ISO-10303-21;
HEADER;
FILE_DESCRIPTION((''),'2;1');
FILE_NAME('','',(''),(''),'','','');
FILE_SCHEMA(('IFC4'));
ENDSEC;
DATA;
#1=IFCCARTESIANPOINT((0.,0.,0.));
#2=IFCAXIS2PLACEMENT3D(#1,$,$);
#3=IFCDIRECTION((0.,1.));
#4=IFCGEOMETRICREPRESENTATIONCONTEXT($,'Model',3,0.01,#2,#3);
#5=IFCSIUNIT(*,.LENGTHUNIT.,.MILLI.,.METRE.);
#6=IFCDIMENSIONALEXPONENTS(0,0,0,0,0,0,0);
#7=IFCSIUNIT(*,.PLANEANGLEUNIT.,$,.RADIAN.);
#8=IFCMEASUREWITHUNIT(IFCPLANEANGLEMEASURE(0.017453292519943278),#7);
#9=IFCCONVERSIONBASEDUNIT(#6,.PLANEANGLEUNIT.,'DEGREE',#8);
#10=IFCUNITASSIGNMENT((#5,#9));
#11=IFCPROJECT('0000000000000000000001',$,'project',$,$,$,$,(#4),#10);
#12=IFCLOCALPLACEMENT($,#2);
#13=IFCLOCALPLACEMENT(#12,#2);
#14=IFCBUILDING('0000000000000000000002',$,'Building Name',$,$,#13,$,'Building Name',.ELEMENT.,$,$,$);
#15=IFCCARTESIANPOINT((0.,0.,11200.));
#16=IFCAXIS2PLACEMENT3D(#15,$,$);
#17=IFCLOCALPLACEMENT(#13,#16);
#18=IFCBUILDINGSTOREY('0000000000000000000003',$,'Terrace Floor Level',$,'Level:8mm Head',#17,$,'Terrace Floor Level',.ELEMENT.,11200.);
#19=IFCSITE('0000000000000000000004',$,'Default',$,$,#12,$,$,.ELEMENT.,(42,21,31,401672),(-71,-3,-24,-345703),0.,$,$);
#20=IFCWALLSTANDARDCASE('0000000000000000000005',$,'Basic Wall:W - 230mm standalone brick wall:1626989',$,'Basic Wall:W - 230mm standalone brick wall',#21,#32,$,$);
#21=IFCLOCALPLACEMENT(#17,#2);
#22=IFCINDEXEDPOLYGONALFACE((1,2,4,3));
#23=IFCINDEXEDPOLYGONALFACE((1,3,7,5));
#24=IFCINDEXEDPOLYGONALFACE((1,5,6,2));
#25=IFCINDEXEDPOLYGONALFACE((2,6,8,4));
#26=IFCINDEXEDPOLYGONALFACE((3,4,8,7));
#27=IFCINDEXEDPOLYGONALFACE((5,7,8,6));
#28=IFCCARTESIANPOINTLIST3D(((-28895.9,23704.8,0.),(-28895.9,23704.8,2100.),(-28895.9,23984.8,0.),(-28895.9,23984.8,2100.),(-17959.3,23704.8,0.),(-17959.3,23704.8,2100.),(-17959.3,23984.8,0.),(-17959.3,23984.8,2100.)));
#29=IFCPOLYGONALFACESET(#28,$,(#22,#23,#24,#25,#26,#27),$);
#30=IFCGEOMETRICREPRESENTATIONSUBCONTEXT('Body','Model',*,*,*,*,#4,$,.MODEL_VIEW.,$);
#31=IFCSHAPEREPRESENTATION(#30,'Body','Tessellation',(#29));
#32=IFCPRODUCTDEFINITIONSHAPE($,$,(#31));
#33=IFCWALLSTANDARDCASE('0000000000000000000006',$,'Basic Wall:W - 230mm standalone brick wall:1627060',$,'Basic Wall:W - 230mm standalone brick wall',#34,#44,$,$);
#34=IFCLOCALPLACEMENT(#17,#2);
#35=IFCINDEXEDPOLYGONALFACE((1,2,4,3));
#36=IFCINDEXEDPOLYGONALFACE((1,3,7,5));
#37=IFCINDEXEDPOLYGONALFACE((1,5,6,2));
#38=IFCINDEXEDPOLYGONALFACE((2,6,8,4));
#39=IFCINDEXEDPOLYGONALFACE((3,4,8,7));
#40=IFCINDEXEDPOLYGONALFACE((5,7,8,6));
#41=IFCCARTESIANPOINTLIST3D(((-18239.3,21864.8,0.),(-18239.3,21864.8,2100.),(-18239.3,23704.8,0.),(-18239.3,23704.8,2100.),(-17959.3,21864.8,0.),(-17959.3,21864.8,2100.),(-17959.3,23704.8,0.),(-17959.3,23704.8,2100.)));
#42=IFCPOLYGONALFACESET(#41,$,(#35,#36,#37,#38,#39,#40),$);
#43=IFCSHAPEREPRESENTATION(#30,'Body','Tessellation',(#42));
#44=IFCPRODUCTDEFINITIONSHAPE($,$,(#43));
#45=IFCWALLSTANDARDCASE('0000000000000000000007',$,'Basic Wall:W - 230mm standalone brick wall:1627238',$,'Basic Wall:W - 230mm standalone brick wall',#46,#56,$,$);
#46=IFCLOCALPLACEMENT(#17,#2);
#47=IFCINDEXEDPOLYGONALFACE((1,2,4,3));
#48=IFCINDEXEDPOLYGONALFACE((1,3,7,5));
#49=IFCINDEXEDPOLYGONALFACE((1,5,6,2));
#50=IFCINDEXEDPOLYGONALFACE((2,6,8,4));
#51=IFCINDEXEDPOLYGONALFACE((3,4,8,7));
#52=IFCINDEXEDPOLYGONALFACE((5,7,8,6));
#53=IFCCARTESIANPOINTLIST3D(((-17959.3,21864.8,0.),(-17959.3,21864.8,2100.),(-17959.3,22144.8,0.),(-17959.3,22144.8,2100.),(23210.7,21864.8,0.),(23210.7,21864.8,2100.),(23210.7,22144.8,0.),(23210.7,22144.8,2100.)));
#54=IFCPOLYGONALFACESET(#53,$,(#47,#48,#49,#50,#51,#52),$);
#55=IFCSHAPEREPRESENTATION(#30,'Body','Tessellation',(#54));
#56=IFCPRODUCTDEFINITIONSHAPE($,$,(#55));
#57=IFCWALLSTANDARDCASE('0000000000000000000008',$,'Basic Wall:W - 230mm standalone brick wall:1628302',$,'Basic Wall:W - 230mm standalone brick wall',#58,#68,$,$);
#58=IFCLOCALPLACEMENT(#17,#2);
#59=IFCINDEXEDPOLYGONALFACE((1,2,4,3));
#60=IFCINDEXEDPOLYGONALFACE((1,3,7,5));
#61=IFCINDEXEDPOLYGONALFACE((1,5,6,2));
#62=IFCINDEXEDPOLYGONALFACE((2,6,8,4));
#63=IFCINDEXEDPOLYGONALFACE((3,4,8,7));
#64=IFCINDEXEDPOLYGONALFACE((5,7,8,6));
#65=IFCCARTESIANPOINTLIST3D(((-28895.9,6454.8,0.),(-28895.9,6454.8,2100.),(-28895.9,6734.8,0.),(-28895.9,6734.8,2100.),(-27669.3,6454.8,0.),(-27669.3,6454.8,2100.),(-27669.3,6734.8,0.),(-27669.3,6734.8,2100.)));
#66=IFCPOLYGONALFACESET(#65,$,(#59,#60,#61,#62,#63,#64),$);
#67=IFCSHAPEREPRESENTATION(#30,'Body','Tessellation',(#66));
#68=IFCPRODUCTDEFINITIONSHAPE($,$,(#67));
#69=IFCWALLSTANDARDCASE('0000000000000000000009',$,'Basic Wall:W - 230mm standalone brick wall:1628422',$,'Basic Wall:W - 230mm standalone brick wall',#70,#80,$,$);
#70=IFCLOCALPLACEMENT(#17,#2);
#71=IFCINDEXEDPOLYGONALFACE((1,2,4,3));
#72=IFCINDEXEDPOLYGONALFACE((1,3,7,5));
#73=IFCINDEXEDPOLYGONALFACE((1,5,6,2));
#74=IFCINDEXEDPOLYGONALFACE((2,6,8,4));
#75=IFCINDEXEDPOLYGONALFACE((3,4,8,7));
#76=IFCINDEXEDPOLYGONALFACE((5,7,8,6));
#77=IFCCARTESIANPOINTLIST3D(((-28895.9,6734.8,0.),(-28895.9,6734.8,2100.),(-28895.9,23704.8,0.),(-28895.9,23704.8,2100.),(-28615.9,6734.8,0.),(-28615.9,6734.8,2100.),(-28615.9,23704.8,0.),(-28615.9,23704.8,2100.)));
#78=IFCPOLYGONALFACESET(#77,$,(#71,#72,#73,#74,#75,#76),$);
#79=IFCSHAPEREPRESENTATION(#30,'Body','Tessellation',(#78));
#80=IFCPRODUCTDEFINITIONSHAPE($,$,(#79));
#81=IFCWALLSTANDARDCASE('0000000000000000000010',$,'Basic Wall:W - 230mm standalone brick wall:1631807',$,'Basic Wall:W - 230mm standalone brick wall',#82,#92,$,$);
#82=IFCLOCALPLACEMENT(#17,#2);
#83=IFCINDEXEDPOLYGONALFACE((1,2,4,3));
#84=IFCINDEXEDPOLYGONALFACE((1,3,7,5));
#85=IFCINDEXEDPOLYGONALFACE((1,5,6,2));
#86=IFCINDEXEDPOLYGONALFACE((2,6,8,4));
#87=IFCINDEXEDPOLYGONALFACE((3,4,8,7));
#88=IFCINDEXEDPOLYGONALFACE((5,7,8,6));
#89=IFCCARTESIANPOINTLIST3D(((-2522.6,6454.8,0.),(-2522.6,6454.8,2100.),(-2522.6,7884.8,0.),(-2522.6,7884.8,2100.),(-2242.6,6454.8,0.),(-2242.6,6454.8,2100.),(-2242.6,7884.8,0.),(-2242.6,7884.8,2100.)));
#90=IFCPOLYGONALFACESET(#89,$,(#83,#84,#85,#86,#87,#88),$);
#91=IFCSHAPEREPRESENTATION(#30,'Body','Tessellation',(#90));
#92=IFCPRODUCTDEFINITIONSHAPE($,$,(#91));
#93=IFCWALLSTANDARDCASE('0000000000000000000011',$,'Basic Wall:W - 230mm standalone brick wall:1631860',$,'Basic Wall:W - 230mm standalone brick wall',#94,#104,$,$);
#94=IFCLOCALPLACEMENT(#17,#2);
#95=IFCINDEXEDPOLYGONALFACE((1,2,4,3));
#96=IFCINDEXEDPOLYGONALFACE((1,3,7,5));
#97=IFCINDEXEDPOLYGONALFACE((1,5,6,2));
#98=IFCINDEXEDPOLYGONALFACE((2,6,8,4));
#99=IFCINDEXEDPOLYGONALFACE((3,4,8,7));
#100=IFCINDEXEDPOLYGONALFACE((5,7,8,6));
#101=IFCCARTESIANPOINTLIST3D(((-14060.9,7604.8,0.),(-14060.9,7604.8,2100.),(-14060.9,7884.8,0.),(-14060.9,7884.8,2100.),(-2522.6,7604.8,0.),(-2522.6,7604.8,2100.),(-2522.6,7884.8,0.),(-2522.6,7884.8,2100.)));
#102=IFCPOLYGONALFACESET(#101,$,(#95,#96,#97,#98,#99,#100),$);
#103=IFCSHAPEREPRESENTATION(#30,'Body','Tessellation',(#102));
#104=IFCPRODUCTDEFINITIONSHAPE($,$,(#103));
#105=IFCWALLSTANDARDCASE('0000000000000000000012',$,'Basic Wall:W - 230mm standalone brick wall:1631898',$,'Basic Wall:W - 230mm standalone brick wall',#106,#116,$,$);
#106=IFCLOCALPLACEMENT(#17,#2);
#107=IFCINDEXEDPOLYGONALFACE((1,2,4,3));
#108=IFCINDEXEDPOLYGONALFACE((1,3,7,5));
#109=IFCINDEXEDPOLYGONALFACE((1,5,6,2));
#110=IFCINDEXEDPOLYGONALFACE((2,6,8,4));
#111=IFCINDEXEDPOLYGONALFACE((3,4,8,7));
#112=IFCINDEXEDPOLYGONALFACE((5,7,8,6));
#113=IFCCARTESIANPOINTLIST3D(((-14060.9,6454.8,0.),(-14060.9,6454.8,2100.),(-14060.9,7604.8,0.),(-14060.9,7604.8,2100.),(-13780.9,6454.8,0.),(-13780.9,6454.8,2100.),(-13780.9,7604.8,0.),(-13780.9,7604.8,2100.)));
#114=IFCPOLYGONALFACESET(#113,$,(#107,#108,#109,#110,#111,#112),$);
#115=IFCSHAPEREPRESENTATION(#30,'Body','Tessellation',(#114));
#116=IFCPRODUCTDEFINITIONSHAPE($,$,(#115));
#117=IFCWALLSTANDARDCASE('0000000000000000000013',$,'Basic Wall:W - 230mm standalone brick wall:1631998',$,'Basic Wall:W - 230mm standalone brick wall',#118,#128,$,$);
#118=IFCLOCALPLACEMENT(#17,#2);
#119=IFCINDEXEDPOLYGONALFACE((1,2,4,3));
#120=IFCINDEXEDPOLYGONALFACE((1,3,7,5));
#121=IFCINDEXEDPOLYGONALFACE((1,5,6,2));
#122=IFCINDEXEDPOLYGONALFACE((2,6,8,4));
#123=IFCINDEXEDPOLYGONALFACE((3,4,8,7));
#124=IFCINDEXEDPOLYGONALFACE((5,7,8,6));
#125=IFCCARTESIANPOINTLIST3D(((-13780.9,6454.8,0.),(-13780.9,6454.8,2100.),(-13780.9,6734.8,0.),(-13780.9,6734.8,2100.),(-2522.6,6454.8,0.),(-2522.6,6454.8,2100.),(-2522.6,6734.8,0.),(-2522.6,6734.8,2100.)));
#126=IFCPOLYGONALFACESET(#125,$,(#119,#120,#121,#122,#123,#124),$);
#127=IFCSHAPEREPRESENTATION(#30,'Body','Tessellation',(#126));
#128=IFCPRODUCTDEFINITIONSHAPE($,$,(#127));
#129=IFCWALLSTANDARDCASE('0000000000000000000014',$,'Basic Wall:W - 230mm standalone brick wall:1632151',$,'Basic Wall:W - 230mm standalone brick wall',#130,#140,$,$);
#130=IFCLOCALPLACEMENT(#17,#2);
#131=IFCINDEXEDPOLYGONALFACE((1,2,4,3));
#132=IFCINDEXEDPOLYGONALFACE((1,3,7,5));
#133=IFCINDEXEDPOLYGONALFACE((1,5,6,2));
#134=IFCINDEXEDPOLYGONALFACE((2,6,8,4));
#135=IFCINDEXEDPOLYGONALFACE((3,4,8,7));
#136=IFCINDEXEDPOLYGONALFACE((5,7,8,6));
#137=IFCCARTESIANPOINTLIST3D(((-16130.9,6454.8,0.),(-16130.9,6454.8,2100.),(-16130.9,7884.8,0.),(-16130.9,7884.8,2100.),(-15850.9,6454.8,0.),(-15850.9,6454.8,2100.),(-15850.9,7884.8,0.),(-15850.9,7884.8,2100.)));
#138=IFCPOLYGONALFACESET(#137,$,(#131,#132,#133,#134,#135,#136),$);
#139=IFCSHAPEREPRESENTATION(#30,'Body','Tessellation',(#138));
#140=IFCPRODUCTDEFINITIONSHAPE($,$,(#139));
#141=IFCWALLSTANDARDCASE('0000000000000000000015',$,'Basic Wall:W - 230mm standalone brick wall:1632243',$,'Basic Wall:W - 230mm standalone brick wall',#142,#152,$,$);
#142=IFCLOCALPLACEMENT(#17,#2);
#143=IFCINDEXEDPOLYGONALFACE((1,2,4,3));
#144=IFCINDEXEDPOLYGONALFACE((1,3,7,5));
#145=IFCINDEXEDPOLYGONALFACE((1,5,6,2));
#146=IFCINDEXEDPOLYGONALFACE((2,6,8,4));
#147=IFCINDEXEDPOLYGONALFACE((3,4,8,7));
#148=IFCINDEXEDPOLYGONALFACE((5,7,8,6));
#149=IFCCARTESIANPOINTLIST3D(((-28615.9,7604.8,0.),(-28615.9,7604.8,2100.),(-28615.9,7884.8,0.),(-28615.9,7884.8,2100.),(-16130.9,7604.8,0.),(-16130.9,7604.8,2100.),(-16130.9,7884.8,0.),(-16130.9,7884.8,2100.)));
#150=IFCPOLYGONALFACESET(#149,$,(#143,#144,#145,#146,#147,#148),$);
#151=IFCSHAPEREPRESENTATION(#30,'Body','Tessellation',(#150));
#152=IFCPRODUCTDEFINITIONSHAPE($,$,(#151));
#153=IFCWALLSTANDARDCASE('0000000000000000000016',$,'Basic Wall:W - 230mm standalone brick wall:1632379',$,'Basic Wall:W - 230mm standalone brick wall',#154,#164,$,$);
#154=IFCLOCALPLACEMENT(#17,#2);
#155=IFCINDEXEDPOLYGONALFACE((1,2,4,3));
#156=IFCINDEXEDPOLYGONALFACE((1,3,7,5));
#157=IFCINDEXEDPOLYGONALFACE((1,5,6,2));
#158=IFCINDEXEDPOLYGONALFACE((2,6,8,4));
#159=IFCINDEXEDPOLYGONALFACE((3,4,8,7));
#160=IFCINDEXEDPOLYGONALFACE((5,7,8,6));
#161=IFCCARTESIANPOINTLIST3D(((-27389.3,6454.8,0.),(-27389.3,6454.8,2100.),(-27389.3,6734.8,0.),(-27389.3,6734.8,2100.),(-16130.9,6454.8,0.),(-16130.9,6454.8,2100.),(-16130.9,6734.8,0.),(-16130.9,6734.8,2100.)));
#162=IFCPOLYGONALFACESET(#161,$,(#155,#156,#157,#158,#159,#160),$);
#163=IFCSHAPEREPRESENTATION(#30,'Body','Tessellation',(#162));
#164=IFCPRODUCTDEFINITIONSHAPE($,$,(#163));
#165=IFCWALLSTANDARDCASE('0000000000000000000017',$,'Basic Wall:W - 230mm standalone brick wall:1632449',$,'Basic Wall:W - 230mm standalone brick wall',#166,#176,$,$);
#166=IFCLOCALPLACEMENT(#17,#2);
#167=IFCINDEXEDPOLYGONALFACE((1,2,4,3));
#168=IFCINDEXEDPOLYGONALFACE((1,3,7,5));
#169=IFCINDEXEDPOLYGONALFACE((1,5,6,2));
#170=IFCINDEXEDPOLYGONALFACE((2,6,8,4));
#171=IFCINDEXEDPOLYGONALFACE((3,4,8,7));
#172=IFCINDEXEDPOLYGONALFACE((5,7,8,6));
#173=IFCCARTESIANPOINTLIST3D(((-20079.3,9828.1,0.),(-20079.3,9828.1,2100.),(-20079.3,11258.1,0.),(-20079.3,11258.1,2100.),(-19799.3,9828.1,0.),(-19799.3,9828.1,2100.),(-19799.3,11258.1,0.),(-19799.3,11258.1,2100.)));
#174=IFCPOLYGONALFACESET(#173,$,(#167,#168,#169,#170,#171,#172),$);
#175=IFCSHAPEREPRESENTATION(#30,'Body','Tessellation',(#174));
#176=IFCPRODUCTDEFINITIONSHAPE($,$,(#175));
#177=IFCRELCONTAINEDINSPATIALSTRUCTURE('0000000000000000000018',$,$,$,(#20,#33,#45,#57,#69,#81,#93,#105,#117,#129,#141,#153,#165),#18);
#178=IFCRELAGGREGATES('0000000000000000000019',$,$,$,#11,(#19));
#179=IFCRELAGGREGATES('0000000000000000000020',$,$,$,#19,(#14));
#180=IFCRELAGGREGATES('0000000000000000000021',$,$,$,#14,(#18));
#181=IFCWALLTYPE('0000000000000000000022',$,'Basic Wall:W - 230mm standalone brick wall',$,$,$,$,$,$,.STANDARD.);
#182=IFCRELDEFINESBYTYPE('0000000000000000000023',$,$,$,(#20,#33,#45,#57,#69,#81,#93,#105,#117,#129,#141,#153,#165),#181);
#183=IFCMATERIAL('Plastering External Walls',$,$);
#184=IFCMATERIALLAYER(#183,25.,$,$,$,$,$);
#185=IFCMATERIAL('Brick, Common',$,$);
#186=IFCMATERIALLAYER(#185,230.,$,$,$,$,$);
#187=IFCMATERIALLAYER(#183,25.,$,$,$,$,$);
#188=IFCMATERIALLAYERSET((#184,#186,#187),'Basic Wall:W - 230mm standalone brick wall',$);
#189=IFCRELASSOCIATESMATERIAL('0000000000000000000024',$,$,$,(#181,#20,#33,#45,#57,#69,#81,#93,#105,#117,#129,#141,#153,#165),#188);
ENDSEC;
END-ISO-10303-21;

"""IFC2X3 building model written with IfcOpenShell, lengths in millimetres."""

from ifc_helpers import new_model, entity, si_unit, converted_unit, direction, frame, frame_2d, origin, place, context, subcontext, project, spatial, rectangle, extrude, material, layer, layer_set, layer_usage, type_object, element, save


model = new_model("IFC2X3")

# Units and contexts
model_context = context("Model", 3, precision=0.01, world=origin(), true_north=direction((0.0, 1.0)))
body_context = subcontext(model_context, "Body", "Model", "MODEL_VIEW")
ifc_project = project(units=[si_unit("LENGTHUNIT", "METRE", prefix="MILLI"), converted_unit("PLANEANGLEUNIT", "DEGREE", entity("IfcPlaneAngleMeasure", 0.017453292519943278), si_unit("PLANEANGLEUNIT", "RADIAN"), dimensions=[0, 0, 0, 0, 0, 0, 0])], contexts=[model_context])

# Site, building, storey
site_placement = place(None, origin())
site = spatial("IfcSite", under=ifc_project, at=site_placement, Name="Default", CompositionType="ELEMENT", RefLatitude=(42, 21, 31, 401672), RefLongitude=(-71, -3, -24, -345703), RefElevation=0.0)
building_placement = place(site_placement, origin())
building = spatial("IfcBuilding", under=site, at=building_placement, Name="Building Name", LongName="Building Name", CompositionType="ELEMENT")
storey_placement = place(building_placement, frame((0.0, 0.0, 11200.0)))
storey = spatial("IfcBuildingStorey", under=building, at=storey_placement, Name="Terrace Floor Level", ObjectType="Level:8mm Head", LongName="Terrace Floor Level", CompositionType="ELEMENT", Elevation=11200.0)

# Walls
ifc_material_1 = material(Name="Plastering External Walls")
ifc_layer_1 = layer(ifc_material_1, 25.0)
ifc_material_2 = material(Name="Brick, Common")
ifc_layer_2 = layer(ifc_material_2, 230.0)
ifc_layer_3 = layer(ifc_material_1, 25.0)
ifc_layer_set = layer_set([ifc_layer_1, ifc_layer_2, ifc_layer_3], Name="Basic Wall:W - 230mm standalone brick wall")
ifc_layer_usage_1 = layer_usage(ifc_layer_set, "AXIS2", "NEGATIVE", 140.0)
wall_type = type_object("IfcWallType", Name="Basic Wall:W - 230mm standalone brick wall", PredefinedType="STANDARD", material=ifc_layer_set)
wall_1_placement = place(storey_placement, frame((-28895.9, 23844.8, 0.0)))
element("IfcWallStandardCase", 1, at=wall_1_placement, inside=storey, type_object=wall_type, material=ifc_layer_usage_1, Name="Basic Wall:W - 230mm standalone brick wall:1626989", ObjectType="Basic Wall:W - 230mm standalone brick wall", context=body_context, shape_type="SweptSolid", body=[
    extrude(rectangle(XDim=10936.7, YDim=280.0, at=frame_2d((5468.3, 0.0), x_axis=(-1.0, 0.0))), origin(), (0.0, 0.0, 1.0), 2100.0),
])
ifc_layer_usage_2 = layer_usage(ifc_layer_set, "AXIS2", "NEGATIVE", 140.0)
wall_2_placement = place(storey_placement, frame((-18099.3, 23704.8, 0.0), z_axis=(0.0, 0.0, 1.0), x_axis=(0.0, -1.0, 0.0)))
element("IfcWallStandardCase", 2, at=wall_2_placement, inside=storey, type_object=wall_type, material=ifc_layer_usage_2, Name="Basic Wall:W - 230mm standalone brick wall:1627060", ObjectType="Basic Wall:W - 230mm standalone brick wall", context=body_context, shape_type="SweptSolid", body=[
    extrude(rectangle(XDim=1840.0, YDim=280.0, at=frame_2d((920.0, 0.0), x_axis=(-1.0, 0.0))), origin(), (0.0, 0.0, 1.0), 2100.0),
])
ifc_layer_usage_3 = layer_usage(ifc_layer_set, "AXIS2", "NEGATIVE", 140.0)
wall_3_placement = place(storey_placement, frame((-17959.3, 22004.8, 0.0)))
element("IfcWallStandardCase", 3, at=wall_3_placement, inside=storey, type_object=wall_type, material=ifc_layer_usage_3, Name="Basic Wall:W - 230mm standalone brick wall:1627238", ObjectType="Basic Wall:W - 230mm standalone brick wall", context=body_context, shape_type="SweptSolid", body=[
    extrude(rectangle(XDim=41170.0, YDim=280.0, at=frame_2d((20585.0, 0.0), x_axis=(-1.0, 0.0))), origin(), (0.0, 0.0, 1.0), 2100.0),
])
ifc_layer_usage_4 = layer_usage(ifc_layer_set, "AXIS2", "NEGATIVE", 140.0)
wall_4_placement = place(storey_placement, frame((-27669.3, 6594.8, 0.0), z_axis=(0.0, 0.0, 1.0), x_axis=(-1.0, 0.0, 0.0)))
element("IfcWallStandardCase", 4, at=wall_4_placement, inside=storey, type_object=wall_type, material=ifc_layer_usage_4, Name="Basic Wall:W - 230mm standalone brick wall:1628302", ObjectType="Basic Wall:W - 230mm standalone brick wall", context=body_context, shape_type="SweptSolid", body=[
    extrude(rectangle(XDim=1226.7, YDim=280.0, at=frame_2d((613.3, 0.0), x_axis=(-1.0, 0.0))), origin(), (0.0, 0.0, 1.0), 2100.0),
])
ifc_layer_usage_5 = layer_usage(ifc_layer_set, "AXIS2", "NEGATIVE", 140.0)
wall_5_placement = place(storey_placement, frame((-28755.9, 6734.8, 0.0), z_axis=(0.0, 0.0, 1.0), x_axis=(0.0, 1.0, 0.0)))
element("IfcWallStandardCase", 5, at=wall_5_placement, inside=storey, type_object=wall_type, material=ifc_layer_usage_5, Name="Basic Wall:W - 230mm standalone brick wall:1628422", ObjectType="Basic Wall:W - 230mm standalone brick wall", context=body_context, shape_type="SweptSolid", body=[
    extrude(rectangle(XDim=16970.0, YDim=280.0, at=frame_2d((8485.0, 0.0), x_axis=(-1.0, 0.0))), origin(), (0.0, 0.0, 1.0), 2100.0),
])
ifc_layer_usage_6 = layer_usage(ifc_layer_set, "AXIS2", "NEGATIVE", 140.0)
wall_6_placement = place(storey_placement, frame((-2382.6, 6454.8, 0.0), z_axis=(0.0, 0.0, 1.0), x_axis=(0.0, 1.0, 0.0)))
element("IfcWallStandardCase", 6, at=wall_6_placement, inside=storey, type_object=wall_type, material=ifc_layer_usage_6, Name="Basic Wall:W - 230mm standalone brick wall:1631807", ObjectType="Basic Wall:W - 230mm standalone brick wall", context=body_context, shape_type="SweptSolid", body=[
    extrude(rectangle(XDim=1430.0, YDim=280.0, at=frame_2d((715.0, 0.0), x_axis=(-1.0, 0.0))), origin(), (0.0, 0.0, 1.0), 2100.0),
])
ifc_layer_usage_7 = layer_usage(ifc_layer_set, "AXIS2", "NEGATIVE", 140.0)
wall_7_placement = place(storey_placement, frame((-2522.6, 7744.8, 0.0), z_axis=(0.0, 0.0, 1.0), x_axis=(-1.0, 0.0, 0.0)))
element("IfcWallStandardCase", 7, at=wall_7_placement, inside=storey, type_object=wall_type, material=ifc_layer_usage_7, Name="Basic Wall:W - 230mm standalone brick wall:1631860", ObjectType="Basic Wall:W - 230mm standalone brick wall", context=body_context, shape_type="SweptSolid", body=[
    extrude(rectangle(XDim=11538.3, YDim=280.0, at=frame_2d((5769.2, 0.0), x_axis=(-1.0, 0.0))), origin(), (0.0, 0.0, 1.0), 2100.0),
])
ifc_layer_usage_8 = layer_usage(ifc_layer_set, "AXIS2", "NEGATIVE", 140.0)
wall_8_placement = place(storey_placement, frame((-13920.9, 7604.8, 0.0), z_axis=(0.0, 0.0, 1.0), x_axis=(0.0, -1.0, 0.0)))
element("IfcWallStandardCase", 8, at=wall_8_placement, inside=storey, type_object=wall_type, material=ifc_layer_usage_8, Name="Basic Wall:W - 230mm standalone brick wall:1631898", ObjectType="Basic Wall:W - 230mm standalone brick wall", context=body_context, shape_type="SweptSolid", body=[
    extrude(rectangle(XDim=1150.0, YDim=280.0, at=frame_2d((575.0, 0.0), x_axis=(-1.0, 0.0))), origin(), (0.0, 0.0, 1.0), 2100.0),
])
ifc_layer_usage_9 = layer_usage(ifc_layer_set, "AXIS2", "NEGATIVE", 140.0)
wall_9_placement = place(storey_placement, frame((-13780.9, 6594.8, 0.0)))
element("IfcWallStandardCase", 9, at=wall_9_placement, inside=storey, type_object=wall_type, material=ifc_layer_usage_9, Name="Basic Wall:W - 230mm standalone brick wall:1631998", ObjectType="Basic Wall:W - 230mm standalone brick wall", context=body_context, shape_type="SweptSolid", body=[
    extrude(rectangle(XDim=11258.3, YDim=280.0, at=frame_2d((5629.2, 0.0), x_axis=(-1.0, 0.0))), origin(), (0.0, 0.0, 1.0), 2100.0),
])
ifc_layer_usage_10 = layer_usage(ifc_layer_set, "AXIS2", "NEGATIVE", 140.0)
wall_10_placement = place(storey_placement, frame((-15990.9, 6454.8, 0.0), z_axis=(0.0, 0.0, 1.0), x_axis=(0.0, 1.0, 0.0)))
element("IfcWallStandardCase", 10, at=wall_10_placement, inside=storey, type_object=wall_type, material=ifc_layer_usage_10, Name="Basic Wall:W - 230mm standalone brick wall:1632151", ObjectType="Basic Wall:W - 230mm standalone brick wall", context=body_context, shape_type="SweptSolid", body=[
    extrude(rectangle(XDim=1430.0, YDim=280.0, at=frame_2d((715.0, 0.0), x_axis=(-1.0, 0.0))), origin(), (0.0, 0.0, 1.0), 2100.0),
])
ifc_layer_usage_11 = layer_usage(ifc_layer_set, "AXIS2", "NEGATIVE", 140.0)
wall_11_placement = place(storey_placement, frame((-16130.9, 7744.8, 0.0), z_axis=(0.0, 0.0, 1.0), x_axis=(-1.0, 0.0, 0.0)))
element("IfcWallStandardCase", 11, at=wall_11_placement, inside=storey, type_object=wall_type, material=ifc_layer_usage_11, Name="Basic Wall:W - 230mm standalone brick wall:1632243", ObjectType="Basic Wall:W - 230mm standalone brick wall", context=body_context, shape_type="SweptSolid", body=[
    extrude(rectangle(XDim=12485.0, YDim=280.0, at=frame_2d((6242.5, 0.0), x_axis=(-1.0, 0.0))), origin(), (0.0, 0.0, 1.0), 2100.0),
])
ifc_layer_usage_12 = layer_usage(ifc_layer_set, "AXIS2", "NEGATIVE", 140.0)
wall_12_placement = place(storey_placement, frame((-27389.3, 6594.8, 0.0)))
element("IfcWallStandardCase", 12, at=wall_12_placement, inside=storey, type_object=wall_type, material=ifc_layer_usage_12, Name="Basic Wall:W - 230mm standalone brick wall:1632379", ObjectType="Basic Wall:W - 230mm standalone brick wall", context=body_context, shape_type="SweptSolid", body=[
    extrude(rectangle(XDim=11258.3, YDim=280.0, at=frame_2d((5629.2, 0.0), x_axis=(-1.0, 0.0))), origin(), (0.0, 0.0, 1.0), 2100.0),
])
ifc_layer_usage_13 = layer_usage(ifc_layer_set, "AXIS2", "NEGATIVE", 140.0)
wall_13_placement = place(storey_placement, frame((-19939.3, 9828.1, 0.0), z_axis=(0.0, 0.0, 1.0), x_axis=(0.0, 1.0, 0.0)))
element("IfcWallStandardCase", 13, at=wall_13_placement, inside=storey, type_object=wall_type, material=ifc_layer_usage_13, Name="Basic Wall:W - 230mm standalone brick wall:1632449", ObjectType="Basic Wall:W - 230mm standalone brick wall", context=body_context, shape_type="SweptSolid", body=[
    extrude(rectangle(XDim=1430.0, YDim=280.0, at=frame_2d((715.0, 0.0), x_axis=(-1.0, 0.0))), origin(), (0.0, 0.0, 1.0), 2100.0),
])

save(model, "model.ifc")
